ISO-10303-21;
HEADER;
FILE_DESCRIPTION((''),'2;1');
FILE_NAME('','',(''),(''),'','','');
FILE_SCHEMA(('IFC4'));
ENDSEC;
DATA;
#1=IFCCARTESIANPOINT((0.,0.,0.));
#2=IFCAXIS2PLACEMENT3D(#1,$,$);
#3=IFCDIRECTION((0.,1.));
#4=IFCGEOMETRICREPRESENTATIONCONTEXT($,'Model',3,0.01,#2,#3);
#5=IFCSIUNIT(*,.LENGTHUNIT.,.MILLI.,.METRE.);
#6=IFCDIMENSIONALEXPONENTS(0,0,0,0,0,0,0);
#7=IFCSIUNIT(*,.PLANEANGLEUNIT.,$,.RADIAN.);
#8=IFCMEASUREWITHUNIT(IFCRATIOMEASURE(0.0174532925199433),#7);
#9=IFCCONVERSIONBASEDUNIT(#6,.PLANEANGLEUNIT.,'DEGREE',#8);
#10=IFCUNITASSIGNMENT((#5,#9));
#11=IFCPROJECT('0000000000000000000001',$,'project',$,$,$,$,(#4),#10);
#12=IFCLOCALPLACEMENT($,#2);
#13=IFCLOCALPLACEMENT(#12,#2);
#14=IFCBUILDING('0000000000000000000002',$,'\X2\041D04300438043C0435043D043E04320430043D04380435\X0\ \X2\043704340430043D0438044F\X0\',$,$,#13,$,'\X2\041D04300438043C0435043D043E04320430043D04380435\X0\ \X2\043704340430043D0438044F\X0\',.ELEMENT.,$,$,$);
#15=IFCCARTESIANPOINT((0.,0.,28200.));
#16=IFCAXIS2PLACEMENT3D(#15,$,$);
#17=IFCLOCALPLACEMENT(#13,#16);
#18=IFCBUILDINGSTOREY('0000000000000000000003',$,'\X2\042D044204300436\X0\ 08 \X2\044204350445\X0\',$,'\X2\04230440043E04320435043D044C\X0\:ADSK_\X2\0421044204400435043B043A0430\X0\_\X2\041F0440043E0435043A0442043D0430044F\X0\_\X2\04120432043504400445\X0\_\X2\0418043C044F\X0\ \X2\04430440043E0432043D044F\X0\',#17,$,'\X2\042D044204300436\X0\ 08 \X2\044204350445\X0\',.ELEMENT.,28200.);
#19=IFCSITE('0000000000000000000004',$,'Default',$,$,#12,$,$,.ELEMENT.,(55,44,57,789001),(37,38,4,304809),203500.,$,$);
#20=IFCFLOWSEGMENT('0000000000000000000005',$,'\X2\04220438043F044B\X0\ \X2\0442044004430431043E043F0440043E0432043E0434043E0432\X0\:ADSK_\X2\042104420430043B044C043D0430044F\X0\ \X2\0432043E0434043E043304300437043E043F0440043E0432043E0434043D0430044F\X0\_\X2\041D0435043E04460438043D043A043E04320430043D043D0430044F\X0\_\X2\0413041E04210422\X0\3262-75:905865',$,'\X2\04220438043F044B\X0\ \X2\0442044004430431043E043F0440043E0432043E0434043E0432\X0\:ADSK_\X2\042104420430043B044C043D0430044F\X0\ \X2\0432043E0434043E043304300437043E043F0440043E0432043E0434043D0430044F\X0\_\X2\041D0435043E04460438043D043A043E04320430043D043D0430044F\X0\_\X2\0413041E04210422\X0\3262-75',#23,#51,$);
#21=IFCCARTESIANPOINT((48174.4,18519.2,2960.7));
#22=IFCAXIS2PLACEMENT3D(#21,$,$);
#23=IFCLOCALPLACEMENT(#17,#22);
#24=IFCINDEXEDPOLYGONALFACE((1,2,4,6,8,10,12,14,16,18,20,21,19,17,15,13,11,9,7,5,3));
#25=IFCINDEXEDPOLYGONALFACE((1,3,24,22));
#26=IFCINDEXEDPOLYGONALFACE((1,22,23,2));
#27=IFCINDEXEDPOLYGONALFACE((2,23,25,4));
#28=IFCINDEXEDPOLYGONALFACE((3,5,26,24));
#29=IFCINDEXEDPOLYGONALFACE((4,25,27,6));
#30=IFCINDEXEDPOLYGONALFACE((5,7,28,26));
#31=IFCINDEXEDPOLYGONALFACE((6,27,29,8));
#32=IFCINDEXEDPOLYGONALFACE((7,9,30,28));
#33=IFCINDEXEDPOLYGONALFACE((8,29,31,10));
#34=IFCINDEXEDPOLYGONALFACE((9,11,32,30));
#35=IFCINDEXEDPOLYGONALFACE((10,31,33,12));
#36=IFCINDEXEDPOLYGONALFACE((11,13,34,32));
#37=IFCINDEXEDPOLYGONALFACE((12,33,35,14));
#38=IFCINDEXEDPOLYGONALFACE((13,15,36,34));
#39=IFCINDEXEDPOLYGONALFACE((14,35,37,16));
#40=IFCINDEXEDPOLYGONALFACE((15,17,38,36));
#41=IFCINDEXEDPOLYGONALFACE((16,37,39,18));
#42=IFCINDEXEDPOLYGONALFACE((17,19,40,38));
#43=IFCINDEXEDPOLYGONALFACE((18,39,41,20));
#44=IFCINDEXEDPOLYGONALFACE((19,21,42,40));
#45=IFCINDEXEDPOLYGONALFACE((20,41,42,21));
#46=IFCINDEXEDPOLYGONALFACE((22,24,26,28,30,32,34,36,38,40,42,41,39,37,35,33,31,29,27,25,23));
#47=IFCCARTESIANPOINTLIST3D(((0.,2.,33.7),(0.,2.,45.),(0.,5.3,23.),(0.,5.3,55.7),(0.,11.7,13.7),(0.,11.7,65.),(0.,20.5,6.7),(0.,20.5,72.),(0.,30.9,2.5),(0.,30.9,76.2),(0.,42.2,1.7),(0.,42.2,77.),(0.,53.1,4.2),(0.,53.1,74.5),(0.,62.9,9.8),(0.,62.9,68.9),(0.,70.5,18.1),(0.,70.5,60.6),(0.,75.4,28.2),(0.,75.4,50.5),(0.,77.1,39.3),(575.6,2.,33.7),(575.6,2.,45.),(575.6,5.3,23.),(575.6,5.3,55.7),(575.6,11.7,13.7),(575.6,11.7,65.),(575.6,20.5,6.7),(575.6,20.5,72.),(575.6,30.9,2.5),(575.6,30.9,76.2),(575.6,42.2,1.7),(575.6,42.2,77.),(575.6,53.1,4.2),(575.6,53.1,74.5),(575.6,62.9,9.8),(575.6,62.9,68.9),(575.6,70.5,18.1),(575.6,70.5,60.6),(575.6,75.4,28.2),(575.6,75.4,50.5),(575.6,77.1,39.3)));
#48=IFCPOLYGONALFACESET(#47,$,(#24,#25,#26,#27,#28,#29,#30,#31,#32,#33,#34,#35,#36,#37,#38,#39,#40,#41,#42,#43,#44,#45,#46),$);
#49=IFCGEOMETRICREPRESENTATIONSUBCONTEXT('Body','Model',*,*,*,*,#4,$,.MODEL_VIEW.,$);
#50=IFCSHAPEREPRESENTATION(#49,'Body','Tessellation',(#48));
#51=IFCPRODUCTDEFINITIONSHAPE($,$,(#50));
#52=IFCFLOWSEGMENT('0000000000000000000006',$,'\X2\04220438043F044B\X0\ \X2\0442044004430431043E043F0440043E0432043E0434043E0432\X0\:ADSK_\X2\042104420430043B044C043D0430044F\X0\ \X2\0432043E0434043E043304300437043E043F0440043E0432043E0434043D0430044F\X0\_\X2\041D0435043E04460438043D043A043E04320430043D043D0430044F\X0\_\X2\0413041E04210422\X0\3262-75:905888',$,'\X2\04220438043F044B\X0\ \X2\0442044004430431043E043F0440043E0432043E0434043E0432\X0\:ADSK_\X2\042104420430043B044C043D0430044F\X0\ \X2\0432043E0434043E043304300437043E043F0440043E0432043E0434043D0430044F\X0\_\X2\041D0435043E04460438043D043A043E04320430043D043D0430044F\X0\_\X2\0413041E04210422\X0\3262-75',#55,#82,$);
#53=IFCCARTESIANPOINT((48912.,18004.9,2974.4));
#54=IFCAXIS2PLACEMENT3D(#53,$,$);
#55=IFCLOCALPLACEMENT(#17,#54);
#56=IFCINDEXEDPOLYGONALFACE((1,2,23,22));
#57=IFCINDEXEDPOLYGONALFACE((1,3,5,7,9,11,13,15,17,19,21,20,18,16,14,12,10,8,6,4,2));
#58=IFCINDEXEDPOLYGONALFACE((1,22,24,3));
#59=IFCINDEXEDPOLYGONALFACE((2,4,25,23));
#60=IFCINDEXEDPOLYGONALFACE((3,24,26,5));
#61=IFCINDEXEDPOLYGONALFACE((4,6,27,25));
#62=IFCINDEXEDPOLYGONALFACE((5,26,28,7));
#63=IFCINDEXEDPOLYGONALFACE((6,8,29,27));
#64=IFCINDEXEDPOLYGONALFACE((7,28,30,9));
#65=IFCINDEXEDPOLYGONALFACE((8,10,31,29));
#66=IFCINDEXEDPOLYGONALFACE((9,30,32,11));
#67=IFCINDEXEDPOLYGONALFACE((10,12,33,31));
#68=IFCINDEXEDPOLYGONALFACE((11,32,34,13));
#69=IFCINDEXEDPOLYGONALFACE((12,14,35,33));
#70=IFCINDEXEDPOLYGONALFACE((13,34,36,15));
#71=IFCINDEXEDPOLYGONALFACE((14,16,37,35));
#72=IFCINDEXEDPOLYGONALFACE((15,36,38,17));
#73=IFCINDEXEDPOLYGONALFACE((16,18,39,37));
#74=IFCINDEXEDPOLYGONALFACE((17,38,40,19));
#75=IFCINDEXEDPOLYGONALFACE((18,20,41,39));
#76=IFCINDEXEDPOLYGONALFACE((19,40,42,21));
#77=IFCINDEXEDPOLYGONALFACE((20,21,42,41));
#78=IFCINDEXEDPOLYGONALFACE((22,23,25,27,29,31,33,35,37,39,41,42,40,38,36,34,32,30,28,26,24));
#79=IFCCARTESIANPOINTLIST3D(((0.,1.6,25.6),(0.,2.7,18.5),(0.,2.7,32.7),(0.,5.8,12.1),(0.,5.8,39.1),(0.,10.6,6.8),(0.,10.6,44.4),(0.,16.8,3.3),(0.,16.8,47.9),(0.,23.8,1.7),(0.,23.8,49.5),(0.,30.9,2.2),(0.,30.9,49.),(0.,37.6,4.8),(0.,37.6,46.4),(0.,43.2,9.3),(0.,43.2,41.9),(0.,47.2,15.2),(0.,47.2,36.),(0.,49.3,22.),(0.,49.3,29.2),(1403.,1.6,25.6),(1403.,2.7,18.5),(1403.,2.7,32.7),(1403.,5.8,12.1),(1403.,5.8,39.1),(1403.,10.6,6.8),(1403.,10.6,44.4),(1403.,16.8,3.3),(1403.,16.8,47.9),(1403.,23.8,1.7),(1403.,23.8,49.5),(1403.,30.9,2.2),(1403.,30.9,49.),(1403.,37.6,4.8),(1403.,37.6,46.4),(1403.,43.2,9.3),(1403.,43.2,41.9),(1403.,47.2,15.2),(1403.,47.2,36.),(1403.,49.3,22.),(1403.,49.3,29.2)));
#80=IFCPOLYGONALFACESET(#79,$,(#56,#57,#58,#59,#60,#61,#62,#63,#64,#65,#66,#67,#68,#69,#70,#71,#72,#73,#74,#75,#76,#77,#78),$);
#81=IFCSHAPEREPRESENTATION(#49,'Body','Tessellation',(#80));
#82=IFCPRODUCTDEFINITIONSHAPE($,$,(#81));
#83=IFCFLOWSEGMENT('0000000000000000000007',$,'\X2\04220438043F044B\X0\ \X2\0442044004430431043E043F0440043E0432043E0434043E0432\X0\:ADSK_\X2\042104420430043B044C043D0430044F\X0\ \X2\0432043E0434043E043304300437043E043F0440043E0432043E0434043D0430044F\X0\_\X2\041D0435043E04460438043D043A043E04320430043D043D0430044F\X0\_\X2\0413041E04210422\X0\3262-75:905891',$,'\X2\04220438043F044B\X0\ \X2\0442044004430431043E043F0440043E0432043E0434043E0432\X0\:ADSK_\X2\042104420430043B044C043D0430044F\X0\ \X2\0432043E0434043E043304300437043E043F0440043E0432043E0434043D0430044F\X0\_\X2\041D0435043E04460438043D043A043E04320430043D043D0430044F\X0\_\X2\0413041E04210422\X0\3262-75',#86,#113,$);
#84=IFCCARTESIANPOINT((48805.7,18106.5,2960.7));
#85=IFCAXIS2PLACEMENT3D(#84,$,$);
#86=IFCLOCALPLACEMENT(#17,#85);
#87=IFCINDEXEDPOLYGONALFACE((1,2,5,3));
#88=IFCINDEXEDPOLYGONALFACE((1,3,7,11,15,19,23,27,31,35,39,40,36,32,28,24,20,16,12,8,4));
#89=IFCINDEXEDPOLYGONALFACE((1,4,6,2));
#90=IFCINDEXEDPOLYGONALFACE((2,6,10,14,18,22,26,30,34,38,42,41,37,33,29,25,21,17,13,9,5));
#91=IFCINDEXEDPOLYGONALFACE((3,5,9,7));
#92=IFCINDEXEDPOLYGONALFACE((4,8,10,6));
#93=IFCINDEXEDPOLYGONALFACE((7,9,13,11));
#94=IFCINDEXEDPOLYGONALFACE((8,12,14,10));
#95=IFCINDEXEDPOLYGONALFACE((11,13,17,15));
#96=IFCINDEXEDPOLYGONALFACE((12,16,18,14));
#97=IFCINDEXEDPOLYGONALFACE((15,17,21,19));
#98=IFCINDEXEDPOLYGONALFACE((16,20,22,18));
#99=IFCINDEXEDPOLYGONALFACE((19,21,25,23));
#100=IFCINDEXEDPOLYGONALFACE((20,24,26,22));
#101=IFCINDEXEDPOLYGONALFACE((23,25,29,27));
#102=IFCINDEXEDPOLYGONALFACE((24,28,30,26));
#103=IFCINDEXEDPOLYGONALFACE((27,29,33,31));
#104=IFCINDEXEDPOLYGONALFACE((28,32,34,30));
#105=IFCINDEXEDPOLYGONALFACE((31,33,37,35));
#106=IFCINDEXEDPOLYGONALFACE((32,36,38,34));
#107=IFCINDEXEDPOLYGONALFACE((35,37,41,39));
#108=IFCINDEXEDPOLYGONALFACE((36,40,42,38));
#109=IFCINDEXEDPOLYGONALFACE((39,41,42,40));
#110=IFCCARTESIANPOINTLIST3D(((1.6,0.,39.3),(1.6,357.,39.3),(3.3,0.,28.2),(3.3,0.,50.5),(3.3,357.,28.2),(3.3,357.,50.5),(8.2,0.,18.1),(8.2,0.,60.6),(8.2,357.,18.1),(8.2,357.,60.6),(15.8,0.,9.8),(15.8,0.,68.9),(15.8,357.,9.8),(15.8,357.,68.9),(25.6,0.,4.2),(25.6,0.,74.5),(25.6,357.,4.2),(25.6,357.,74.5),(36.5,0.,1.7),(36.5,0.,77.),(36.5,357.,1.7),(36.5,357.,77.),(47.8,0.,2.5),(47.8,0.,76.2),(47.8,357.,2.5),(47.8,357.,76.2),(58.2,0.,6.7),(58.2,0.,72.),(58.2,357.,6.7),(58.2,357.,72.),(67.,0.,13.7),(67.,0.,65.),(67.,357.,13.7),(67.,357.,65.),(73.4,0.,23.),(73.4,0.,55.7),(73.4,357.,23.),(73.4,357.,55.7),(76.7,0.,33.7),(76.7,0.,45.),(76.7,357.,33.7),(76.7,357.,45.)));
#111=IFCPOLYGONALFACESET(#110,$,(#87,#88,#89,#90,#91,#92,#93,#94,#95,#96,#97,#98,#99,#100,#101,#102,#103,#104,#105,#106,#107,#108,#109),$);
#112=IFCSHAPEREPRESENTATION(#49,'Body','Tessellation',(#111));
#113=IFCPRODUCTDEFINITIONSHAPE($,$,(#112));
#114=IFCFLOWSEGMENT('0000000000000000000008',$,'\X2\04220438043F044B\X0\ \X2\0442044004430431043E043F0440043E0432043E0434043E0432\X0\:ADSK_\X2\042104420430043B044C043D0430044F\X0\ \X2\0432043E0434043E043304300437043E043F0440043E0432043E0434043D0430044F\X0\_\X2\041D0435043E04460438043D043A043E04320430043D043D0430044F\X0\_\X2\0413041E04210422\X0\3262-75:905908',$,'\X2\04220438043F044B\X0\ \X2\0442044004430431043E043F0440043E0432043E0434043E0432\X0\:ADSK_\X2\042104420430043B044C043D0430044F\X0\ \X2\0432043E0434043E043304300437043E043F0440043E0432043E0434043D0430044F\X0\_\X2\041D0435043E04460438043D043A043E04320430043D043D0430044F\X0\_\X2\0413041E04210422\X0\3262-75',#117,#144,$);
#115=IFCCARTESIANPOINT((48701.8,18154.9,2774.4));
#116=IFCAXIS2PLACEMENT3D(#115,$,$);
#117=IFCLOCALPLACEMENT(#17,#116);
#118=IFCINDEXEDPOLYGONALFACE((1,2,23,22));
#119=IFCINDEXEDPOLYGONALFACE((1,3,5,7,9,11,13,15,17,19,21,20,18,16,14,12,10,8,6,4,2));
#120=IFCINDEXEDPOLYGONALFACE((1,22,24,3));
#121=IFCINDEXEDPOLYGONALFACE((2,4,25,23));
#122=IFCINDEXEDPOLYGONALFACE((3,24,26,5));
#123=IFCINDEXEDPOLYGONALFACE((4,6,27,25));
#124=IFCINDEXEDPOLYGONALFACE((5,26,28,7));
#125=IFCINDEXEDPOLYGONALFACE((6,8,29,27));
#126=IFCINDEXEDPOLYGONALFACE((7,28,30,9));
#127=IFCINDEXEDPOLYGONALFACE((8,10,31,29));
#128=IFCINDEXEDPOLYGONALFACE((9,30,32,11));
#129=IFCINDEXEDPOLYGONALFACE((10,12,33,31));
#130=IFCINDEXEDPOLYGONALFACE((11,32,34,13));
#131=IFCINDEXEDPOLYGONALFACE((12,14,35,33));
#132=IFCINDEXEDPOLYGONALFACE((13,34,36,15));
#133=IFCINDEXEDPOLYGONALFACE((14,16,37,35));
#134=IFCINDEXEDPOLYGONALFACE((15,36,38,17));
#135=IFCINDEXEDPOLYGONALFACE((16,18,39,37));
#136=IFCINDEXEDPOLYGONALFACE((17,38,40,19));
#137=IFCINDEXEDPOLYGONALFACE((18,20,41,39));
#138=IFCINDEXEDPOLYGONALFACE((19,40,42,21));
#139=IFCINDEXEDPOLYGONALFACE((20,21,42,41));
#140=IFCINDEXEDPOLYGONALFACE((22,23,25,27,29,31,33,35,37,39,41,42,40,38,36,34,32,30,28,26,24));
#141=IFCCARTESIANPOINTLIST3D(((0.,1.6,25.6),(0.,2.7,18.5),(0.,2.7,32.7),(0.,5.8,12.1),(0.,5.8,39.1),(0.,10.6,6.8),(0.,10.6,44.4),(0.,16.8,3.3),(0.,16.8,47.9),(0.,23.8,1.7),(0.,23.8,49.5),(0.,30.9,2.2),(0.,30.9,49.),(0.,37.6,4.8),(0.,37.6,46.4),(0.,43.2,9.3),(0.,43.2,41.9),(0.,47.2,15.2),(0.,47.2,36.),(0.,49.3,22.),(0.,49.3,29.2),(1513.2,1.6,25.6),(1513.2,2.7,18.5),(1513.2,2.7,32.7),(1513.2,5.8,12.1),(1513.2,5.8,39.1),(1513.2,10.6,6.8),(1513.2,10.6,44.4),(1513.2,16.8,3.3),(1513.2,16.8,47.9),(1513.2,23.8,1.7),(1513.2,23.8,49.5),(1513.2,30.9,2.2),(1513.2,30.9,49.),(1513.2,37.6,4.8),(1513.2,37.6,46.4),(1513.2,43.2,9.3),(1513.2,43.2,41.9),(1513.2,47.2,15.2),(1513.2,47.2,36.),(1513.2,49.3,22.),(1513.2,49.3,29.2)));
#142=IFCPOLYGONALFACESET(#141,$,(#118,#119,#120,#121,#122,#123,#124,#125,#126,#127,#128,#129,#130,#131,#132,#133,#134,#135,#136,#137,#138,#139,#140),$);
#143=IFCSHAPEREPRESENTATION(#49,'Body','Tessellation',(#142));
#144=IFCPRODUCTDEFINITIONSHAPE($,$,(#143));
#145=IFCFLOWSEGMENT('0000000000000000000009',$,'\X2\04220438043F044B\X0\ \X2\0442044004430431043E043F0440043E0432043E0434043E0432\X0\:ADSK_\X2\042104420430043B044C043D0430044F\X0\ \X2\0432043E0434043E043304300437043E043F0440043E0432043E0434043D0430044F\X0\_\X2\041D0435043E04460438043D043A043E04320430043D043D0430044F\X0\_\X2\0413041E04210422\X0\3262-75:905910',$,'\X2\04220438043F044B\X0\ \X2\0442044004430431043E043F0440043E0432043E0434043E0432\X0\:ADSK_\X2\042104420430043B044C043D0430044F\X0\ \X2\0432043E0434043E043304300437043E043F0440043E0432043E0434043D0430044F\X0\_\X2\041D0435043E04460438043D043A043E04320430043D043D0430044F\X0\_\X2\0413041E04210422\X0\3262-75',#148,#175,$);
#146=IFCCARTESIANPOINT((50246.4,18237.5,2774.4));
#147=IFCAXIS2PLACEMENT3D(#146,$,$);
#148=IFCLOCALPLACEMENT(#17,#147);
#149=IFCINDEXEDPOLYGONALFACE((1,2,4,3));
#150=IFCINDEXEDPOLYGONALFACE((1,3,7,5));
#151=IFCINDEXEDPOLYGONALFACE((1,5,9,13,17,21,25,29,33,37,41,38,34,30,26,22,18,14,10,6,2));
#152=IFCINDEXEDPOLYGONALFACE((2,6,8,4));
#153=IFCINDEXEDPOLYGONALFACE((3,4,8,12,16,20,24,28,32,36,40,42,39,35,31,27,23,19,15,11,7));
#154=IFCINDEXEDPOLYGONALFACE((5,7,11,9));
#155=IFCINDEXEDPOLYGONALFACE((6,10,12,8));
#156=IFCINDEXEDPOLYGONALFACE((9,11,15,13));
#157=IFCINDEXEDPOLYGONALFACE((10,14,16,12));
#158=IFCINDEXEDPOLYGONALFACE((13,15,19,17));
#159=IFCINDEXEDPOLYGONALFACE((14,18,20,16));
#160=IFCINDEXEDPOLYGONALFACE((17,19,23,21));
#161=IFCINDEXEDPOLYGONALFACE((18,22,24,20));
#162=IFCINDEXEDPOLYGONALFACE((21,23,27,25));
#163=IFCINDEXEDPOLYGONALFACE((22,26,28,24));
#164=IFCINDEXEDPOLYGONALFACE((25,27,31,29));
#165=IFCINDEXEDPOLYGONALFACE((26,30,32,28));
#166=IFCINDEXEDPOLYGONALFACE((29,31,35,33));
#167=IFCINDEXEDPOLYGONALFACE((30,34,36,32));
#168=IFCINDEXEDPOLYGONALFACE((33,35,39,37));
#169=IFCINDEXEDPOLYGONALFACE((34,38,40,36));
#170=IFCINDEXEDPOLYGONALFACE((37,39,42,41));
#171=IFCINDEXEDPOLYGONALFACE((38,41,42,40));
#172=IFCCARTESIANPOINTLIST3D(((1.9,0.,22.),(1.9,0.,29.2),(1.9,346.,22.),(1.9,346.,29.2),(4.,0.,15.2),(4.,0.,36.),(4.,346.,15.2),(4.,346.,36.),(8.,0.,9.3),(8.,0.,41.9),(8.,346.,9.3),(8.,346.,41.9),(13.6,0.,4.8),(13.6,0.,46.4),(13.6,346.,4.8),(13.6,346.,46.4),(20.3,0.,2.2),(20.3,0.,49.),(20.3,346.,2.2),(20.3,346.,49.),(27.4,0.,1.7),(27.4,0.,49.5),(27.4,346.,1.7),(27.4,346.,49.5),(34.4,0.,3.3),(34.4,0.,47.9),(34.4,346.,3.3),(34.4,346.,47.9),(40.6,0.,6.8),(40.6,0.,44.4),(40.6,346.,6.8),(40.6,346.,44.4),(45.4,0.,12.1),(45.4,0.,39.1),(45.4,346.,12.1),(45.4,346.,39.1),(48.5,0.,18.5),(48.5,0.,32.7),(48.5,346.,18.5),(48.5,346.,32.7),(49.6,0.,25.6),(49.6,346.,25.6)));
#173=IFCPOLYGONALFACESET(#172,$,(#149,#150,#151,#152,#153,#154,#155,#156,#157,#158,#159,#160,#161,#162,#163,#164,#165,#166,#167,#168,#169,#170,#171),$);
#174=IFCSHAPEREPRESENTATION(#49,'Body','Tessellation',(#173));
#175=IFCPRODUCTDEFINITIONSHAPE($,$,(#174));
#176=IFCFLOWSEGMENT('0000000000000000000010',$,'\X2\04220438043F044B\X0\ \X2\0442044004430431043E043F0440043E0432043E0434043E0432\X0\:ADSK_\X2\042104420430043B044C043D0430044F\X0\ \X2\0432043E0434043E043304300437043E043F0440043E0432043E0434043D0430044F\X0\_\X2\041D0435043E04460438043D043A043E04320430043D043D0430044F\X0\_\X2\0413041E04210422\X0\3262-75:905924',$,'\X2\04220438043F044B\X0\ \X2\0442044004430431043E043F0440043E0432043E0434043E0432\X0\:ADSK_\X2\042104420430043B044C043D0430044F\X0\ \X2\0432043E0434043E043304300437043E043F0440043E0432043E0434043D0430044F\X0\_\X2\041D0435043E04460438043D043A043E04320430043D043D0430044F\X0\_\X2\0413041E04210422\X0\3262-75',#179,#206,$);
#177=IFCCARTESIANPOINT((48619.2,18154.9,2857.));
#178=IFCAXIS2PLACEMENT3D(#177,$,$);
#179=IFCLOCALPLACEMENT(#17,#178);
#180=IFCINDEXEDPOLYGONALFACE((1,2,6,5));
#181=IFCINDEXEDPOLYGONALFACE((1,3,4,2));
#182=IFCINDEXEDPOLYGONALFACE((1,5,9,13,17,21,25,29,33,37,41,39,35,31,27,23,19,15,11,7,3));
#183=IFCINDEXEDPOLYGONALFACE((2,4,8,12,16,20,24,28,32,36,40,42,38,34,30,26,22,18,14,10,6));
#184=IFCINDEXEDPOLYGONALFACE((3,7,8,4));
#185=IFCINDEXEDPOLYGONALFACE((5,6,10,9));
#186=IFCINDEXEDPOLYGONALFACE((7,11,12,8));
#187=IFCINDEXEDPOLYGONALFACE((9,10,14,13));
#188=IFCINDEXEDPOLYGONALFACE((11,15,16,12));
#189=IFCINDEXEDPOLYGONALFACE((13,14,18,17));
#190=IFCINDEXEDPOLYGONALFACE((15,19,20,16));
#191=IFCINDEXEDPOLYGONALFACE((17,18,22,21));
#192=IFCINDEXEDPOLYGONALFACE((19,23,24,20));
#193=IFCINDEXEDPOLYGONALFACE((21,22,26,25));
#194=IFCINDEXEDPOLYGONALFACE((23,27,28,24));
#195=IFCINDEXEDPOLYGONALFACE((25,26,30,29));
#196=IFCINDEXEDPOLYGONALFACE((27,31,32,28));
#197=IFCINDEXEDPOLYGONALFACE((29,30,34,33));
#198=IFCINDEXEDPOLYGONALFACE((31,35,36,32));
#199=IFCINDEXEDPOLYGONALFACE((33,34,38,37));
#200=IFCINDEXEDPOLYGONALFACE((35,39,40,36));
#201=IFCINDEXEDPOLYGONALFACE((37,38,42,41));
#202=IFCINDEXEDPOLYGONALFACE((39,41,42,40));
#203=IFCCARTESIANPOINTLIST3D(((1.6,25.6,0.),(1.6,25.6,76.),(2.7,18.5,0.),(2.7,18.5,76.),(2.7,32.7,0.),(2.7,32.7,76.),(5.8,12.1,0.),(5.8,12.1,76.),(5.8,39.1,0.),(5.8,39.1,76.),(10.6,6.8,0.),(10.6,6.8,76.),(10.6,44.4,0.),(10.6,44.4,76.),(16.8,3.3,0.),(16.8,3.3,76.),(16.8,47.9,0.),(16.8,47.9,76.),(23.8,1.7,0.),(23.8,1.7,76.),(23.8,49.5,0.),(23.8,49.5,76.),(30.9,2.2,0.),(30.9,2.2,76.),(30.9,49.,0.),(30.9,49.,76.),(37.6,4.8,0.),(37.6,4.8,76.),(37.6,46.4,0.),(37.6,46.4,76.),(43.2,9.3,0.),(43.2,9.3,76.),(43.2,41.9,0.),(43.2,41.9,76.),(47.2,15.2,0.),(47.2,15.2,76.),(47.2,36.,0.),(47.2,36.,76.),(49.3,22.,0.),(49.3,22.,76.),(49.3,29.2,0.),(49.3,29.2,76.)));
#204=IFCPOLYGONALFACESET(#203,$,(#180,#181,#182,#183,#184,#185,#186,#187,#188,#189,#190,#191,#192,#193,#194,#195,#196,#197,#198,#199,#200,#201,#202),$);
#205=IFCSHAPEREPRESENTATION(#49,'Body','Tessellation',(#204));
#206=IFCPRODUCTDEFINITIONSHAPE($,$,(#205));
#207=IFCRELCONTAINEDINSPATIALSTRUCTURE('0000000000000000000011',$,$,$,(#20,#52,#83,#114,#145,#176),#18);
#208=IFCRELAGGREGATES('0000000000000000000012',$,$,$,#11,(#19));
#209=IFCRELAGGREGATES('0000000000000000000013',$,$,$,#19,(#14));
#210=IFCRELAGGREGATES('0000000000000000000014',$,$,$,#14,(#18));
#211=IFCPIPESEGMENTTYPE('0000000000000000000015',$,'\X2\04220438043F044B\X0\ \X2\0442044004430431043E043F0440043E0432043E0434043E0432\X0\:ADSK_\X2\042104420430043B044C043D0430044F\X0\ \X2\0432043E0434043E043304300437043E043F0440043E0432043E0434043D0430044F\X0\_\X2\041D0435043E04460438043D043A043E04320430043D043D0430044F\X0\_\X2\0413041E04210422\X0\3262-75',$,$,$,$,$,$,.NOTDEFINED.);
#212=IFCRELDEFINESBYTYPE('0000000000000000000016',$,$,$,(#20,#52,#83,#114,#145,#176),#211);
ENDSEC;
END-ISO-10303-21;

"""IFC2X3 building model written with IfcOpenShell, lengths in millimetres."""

from ifc_helpers import new_model, entity, si_unit, converted_unit, direction, frame, origin, origin_2d_with_axis, place, context, subcontext, project, spatial, circle, extrude, type_object, element, save


model = new_model("IFC2X3")

# Units and contexts
model_context = context("Model", 3, precision=0.01, world=origin(), true_north=direction((0.0, 1.0)))
body_context = subcontext(model_context, "Body", "Model", "MODEL_VIEW")
ifc_project = project(units=[si_unit("LENGTHUNIT", "METRE", prefix="MILLI"), converted_unit("PLANEANGLEUNIT", "DEGREE", entity("IfcRatioMeasure", 0.0174532925199433), si_unit("PLANEANGLEUNIT", "RADIAN"), dimensions=[0, 0, 0, 0, 0, 0, 0])], contexts=[model_context])

# Site, building, storey
site_placement = place(None, origin())
site = spatial("IfcSite", under=ifc_project, at=site_placement, Name="Default", CompositionType="ELEMENT", RefLatitude=(55, 44, 57, 789001), RefLongitude=(37, 38, 4, 304809), RefElevation=203500.0)
building_placement = place(site_placement, origin())
building = spatial("IfcBuilding", under=site, at=building_placement, Name="Наименование здания", LongName="Наименование здания", CompositionType="ELEMENT")
storey_placement = place(building_placement, frame((0.0, 0.0, 28200.0)))
storey = spatial("IfcBuildingStorey", under=building, at=storey_placement, Name="Этаж 08 тех", ObjectType="Уровень:ADSK_Стрелка_Проектная_Вверх_Имя уровня", LongName="Этаж 08 тех", CompositionType="ELEMENT", Elevation=28200.0)

# Flow segments
pipe_segment_type = type_object("IfcPipeSegmentType", Name="Типы трубопроводов:ADSK_Стальная водогазопроводная_Неоцинкованная_ГОСТ3262-75", PredefinedType="NOTDEFINED")
flow_segment_1_placement = place(storey_placement, frame((48174.4, 18519.2, 2960.7)))
element("IfcFlowSegment", 1, at=flow_segment_1_placement, inside=storey, type_object=pipe_segment_type, Name="Типы трубопроводов:ADSK_Стальная водогазопроводная_Неоцинкованная_ГОСТ3262-75:905865", ObjectType="Типы трубопроводов:ADSK_Стальная водогазопроводная_Неоцинкованная_ГОСТ3262-75", context=body_context, shape_type="SweptSolid", body=[
    extrude(circle(Radius=37.8, at=origin_2d_with_axis()), frame((0.0, 39.4, 39.4), z_axis=(1.0, 0.0, 0.0), x_axis=(0.0, 1.0, 0.0)), (0.0, 0.0, 1.0), 575.6),
])
flow_segment_2_placement = place(storey_placement, frame((48912.0, 18004.9, 2974.4)))
element("IfcFlowSegment", 2, at=flow_segment_2_placement, inside=storey, type_object=pipe_segment_type, Name="Типы трубопроводов:ADSK_Стальная водогазопроводная_Неоцинкованная_ГОСТ3262-75:905888", ObjectType="Типы трубопроводов:ADSK_Стальная водогазопроводная_Неоцинкованная_ГОСТ3262-75", context=body_context, shape_type="SweptSolid", body=[
    extrude(circle(Radius=24.0, at=origin_2d_with_axis()), frame((0.0, 25.6, 25.6), z_axis=(1.0, 0.0, 0.0), x_axis=(0.0, -1.0, 0.0)), (0.0, 0.0, 1.0), 1403.0),
])
flow_segment_3_placement = place(storey_placement, frame((48805.7, 18106.5, 2960.7)))
element("IfcFlowSegment", 3, at=flow_segment_3_placement, inside=storey, type_object=pipe_segment_type, Name="Типы трубопроводов:ADSK_Стальная водогазопроводная_Неоцинкованная_ГОСТ3262-75:905891", ObjectType="Типы трубопроводов:ADSK_Стальная водогазопроводная_Неоцинкованная_ГОСТ3262-75", context=body_context, shape_type="SweptSolid", body=[
    extrude(circle(Radius=37.8, at=origin_2d_with_axis()), frame((39.4, 0.0, 39.4), z_axis=(0.0, 1.0, 0.0), x_axis=(-1.0, 0.0, 0.0)), (0.0, 0.0, 1.0), 357.0),
])
flow_segment_4_placement = place(storey_placement, frame((48701.8, 18154.9, 2774.4)))
element("IfcFlowSegment", 4, at=flow_segment_4_placement, inside=storey, type_object=pipe_segment_type, Name="Типы трубопроводов:ADSK_Стальная водогазопроводная_Неоцинкованная_ГОСТ3262-75:905908", ObjectType="Типы трубопроводов:ADSK_Стальная водогазопроводная_Неоцинкованная_ГОСТ3262-75", context=body_context, shape_type="SweptSolid", body=[
    extrude(circle(Radius=24.0, at=origin_2d_with_axis()), frame((0.0, 25.6, 25.6), z_axis=(1.0, 0.0, 0.0), x_axis=(0.0, -1.0, 0.0)), (0.0, 0.0, 1.0), 1513.2),
])
flow_segment_5_placement = place(storey_placement, frame((50246.4, 18237.5, 2774.4)))
element("IfcFlowSegment", 5, at=flow_segment_5_placement, inside=storey, type_object=pipe_segment_type, Name="Типы трубопроводов:ADSK_Стальная водогазопроводная_Неоцинкованная_ГОСТ3262-75:905910", ObjectType="Типы трубопроводов:ADSK_Стальная водогазопроводная_Неоцинкованная_ГОСТ3262-75", context=body_context, shape_type="SweptSolid", body=[
    extrude(circle(Radius=24.0, at=origin_2d_with_axis()), frame((25.6, 0.0, 25.6), z_axis=(0.0, 1.0, 0.0), x_axis=(1.0, 0.0, 0.0)), (0.0, 0.0, 1.0), 346.0),
])
flow_segment_6_placement = place(storey_placement, frame((48619.2, 18154.9, 2857.0)))
element("IfcFlowSegment", 6, at=flow_segment_6_placement, inside=storey, type_object=pipe_segment_type, Name="Типы трубопроводов:ADSK_Стальная водогазопроводная_Неоцинкованная_ГОСТ3262-75:905924", ObjectType="Типы трубопроводов:ADSK_Стальная водогазопроводная_Неоцинкованная_ГОСТ3262-75", context=body_context, shape_type="SweptSolid", body=[
    extrude(circle(Radius=24.0, at=origin_2d_with_axis()), frame((25.6, 25.6, 0.0), z_axis=(0.0, 0.0, 1.0), x_axis=(-1.0, 0.0, 0.0)), (0.0, 0.0, 1.0), 76.0),
])

save(model, "model.ifc")
